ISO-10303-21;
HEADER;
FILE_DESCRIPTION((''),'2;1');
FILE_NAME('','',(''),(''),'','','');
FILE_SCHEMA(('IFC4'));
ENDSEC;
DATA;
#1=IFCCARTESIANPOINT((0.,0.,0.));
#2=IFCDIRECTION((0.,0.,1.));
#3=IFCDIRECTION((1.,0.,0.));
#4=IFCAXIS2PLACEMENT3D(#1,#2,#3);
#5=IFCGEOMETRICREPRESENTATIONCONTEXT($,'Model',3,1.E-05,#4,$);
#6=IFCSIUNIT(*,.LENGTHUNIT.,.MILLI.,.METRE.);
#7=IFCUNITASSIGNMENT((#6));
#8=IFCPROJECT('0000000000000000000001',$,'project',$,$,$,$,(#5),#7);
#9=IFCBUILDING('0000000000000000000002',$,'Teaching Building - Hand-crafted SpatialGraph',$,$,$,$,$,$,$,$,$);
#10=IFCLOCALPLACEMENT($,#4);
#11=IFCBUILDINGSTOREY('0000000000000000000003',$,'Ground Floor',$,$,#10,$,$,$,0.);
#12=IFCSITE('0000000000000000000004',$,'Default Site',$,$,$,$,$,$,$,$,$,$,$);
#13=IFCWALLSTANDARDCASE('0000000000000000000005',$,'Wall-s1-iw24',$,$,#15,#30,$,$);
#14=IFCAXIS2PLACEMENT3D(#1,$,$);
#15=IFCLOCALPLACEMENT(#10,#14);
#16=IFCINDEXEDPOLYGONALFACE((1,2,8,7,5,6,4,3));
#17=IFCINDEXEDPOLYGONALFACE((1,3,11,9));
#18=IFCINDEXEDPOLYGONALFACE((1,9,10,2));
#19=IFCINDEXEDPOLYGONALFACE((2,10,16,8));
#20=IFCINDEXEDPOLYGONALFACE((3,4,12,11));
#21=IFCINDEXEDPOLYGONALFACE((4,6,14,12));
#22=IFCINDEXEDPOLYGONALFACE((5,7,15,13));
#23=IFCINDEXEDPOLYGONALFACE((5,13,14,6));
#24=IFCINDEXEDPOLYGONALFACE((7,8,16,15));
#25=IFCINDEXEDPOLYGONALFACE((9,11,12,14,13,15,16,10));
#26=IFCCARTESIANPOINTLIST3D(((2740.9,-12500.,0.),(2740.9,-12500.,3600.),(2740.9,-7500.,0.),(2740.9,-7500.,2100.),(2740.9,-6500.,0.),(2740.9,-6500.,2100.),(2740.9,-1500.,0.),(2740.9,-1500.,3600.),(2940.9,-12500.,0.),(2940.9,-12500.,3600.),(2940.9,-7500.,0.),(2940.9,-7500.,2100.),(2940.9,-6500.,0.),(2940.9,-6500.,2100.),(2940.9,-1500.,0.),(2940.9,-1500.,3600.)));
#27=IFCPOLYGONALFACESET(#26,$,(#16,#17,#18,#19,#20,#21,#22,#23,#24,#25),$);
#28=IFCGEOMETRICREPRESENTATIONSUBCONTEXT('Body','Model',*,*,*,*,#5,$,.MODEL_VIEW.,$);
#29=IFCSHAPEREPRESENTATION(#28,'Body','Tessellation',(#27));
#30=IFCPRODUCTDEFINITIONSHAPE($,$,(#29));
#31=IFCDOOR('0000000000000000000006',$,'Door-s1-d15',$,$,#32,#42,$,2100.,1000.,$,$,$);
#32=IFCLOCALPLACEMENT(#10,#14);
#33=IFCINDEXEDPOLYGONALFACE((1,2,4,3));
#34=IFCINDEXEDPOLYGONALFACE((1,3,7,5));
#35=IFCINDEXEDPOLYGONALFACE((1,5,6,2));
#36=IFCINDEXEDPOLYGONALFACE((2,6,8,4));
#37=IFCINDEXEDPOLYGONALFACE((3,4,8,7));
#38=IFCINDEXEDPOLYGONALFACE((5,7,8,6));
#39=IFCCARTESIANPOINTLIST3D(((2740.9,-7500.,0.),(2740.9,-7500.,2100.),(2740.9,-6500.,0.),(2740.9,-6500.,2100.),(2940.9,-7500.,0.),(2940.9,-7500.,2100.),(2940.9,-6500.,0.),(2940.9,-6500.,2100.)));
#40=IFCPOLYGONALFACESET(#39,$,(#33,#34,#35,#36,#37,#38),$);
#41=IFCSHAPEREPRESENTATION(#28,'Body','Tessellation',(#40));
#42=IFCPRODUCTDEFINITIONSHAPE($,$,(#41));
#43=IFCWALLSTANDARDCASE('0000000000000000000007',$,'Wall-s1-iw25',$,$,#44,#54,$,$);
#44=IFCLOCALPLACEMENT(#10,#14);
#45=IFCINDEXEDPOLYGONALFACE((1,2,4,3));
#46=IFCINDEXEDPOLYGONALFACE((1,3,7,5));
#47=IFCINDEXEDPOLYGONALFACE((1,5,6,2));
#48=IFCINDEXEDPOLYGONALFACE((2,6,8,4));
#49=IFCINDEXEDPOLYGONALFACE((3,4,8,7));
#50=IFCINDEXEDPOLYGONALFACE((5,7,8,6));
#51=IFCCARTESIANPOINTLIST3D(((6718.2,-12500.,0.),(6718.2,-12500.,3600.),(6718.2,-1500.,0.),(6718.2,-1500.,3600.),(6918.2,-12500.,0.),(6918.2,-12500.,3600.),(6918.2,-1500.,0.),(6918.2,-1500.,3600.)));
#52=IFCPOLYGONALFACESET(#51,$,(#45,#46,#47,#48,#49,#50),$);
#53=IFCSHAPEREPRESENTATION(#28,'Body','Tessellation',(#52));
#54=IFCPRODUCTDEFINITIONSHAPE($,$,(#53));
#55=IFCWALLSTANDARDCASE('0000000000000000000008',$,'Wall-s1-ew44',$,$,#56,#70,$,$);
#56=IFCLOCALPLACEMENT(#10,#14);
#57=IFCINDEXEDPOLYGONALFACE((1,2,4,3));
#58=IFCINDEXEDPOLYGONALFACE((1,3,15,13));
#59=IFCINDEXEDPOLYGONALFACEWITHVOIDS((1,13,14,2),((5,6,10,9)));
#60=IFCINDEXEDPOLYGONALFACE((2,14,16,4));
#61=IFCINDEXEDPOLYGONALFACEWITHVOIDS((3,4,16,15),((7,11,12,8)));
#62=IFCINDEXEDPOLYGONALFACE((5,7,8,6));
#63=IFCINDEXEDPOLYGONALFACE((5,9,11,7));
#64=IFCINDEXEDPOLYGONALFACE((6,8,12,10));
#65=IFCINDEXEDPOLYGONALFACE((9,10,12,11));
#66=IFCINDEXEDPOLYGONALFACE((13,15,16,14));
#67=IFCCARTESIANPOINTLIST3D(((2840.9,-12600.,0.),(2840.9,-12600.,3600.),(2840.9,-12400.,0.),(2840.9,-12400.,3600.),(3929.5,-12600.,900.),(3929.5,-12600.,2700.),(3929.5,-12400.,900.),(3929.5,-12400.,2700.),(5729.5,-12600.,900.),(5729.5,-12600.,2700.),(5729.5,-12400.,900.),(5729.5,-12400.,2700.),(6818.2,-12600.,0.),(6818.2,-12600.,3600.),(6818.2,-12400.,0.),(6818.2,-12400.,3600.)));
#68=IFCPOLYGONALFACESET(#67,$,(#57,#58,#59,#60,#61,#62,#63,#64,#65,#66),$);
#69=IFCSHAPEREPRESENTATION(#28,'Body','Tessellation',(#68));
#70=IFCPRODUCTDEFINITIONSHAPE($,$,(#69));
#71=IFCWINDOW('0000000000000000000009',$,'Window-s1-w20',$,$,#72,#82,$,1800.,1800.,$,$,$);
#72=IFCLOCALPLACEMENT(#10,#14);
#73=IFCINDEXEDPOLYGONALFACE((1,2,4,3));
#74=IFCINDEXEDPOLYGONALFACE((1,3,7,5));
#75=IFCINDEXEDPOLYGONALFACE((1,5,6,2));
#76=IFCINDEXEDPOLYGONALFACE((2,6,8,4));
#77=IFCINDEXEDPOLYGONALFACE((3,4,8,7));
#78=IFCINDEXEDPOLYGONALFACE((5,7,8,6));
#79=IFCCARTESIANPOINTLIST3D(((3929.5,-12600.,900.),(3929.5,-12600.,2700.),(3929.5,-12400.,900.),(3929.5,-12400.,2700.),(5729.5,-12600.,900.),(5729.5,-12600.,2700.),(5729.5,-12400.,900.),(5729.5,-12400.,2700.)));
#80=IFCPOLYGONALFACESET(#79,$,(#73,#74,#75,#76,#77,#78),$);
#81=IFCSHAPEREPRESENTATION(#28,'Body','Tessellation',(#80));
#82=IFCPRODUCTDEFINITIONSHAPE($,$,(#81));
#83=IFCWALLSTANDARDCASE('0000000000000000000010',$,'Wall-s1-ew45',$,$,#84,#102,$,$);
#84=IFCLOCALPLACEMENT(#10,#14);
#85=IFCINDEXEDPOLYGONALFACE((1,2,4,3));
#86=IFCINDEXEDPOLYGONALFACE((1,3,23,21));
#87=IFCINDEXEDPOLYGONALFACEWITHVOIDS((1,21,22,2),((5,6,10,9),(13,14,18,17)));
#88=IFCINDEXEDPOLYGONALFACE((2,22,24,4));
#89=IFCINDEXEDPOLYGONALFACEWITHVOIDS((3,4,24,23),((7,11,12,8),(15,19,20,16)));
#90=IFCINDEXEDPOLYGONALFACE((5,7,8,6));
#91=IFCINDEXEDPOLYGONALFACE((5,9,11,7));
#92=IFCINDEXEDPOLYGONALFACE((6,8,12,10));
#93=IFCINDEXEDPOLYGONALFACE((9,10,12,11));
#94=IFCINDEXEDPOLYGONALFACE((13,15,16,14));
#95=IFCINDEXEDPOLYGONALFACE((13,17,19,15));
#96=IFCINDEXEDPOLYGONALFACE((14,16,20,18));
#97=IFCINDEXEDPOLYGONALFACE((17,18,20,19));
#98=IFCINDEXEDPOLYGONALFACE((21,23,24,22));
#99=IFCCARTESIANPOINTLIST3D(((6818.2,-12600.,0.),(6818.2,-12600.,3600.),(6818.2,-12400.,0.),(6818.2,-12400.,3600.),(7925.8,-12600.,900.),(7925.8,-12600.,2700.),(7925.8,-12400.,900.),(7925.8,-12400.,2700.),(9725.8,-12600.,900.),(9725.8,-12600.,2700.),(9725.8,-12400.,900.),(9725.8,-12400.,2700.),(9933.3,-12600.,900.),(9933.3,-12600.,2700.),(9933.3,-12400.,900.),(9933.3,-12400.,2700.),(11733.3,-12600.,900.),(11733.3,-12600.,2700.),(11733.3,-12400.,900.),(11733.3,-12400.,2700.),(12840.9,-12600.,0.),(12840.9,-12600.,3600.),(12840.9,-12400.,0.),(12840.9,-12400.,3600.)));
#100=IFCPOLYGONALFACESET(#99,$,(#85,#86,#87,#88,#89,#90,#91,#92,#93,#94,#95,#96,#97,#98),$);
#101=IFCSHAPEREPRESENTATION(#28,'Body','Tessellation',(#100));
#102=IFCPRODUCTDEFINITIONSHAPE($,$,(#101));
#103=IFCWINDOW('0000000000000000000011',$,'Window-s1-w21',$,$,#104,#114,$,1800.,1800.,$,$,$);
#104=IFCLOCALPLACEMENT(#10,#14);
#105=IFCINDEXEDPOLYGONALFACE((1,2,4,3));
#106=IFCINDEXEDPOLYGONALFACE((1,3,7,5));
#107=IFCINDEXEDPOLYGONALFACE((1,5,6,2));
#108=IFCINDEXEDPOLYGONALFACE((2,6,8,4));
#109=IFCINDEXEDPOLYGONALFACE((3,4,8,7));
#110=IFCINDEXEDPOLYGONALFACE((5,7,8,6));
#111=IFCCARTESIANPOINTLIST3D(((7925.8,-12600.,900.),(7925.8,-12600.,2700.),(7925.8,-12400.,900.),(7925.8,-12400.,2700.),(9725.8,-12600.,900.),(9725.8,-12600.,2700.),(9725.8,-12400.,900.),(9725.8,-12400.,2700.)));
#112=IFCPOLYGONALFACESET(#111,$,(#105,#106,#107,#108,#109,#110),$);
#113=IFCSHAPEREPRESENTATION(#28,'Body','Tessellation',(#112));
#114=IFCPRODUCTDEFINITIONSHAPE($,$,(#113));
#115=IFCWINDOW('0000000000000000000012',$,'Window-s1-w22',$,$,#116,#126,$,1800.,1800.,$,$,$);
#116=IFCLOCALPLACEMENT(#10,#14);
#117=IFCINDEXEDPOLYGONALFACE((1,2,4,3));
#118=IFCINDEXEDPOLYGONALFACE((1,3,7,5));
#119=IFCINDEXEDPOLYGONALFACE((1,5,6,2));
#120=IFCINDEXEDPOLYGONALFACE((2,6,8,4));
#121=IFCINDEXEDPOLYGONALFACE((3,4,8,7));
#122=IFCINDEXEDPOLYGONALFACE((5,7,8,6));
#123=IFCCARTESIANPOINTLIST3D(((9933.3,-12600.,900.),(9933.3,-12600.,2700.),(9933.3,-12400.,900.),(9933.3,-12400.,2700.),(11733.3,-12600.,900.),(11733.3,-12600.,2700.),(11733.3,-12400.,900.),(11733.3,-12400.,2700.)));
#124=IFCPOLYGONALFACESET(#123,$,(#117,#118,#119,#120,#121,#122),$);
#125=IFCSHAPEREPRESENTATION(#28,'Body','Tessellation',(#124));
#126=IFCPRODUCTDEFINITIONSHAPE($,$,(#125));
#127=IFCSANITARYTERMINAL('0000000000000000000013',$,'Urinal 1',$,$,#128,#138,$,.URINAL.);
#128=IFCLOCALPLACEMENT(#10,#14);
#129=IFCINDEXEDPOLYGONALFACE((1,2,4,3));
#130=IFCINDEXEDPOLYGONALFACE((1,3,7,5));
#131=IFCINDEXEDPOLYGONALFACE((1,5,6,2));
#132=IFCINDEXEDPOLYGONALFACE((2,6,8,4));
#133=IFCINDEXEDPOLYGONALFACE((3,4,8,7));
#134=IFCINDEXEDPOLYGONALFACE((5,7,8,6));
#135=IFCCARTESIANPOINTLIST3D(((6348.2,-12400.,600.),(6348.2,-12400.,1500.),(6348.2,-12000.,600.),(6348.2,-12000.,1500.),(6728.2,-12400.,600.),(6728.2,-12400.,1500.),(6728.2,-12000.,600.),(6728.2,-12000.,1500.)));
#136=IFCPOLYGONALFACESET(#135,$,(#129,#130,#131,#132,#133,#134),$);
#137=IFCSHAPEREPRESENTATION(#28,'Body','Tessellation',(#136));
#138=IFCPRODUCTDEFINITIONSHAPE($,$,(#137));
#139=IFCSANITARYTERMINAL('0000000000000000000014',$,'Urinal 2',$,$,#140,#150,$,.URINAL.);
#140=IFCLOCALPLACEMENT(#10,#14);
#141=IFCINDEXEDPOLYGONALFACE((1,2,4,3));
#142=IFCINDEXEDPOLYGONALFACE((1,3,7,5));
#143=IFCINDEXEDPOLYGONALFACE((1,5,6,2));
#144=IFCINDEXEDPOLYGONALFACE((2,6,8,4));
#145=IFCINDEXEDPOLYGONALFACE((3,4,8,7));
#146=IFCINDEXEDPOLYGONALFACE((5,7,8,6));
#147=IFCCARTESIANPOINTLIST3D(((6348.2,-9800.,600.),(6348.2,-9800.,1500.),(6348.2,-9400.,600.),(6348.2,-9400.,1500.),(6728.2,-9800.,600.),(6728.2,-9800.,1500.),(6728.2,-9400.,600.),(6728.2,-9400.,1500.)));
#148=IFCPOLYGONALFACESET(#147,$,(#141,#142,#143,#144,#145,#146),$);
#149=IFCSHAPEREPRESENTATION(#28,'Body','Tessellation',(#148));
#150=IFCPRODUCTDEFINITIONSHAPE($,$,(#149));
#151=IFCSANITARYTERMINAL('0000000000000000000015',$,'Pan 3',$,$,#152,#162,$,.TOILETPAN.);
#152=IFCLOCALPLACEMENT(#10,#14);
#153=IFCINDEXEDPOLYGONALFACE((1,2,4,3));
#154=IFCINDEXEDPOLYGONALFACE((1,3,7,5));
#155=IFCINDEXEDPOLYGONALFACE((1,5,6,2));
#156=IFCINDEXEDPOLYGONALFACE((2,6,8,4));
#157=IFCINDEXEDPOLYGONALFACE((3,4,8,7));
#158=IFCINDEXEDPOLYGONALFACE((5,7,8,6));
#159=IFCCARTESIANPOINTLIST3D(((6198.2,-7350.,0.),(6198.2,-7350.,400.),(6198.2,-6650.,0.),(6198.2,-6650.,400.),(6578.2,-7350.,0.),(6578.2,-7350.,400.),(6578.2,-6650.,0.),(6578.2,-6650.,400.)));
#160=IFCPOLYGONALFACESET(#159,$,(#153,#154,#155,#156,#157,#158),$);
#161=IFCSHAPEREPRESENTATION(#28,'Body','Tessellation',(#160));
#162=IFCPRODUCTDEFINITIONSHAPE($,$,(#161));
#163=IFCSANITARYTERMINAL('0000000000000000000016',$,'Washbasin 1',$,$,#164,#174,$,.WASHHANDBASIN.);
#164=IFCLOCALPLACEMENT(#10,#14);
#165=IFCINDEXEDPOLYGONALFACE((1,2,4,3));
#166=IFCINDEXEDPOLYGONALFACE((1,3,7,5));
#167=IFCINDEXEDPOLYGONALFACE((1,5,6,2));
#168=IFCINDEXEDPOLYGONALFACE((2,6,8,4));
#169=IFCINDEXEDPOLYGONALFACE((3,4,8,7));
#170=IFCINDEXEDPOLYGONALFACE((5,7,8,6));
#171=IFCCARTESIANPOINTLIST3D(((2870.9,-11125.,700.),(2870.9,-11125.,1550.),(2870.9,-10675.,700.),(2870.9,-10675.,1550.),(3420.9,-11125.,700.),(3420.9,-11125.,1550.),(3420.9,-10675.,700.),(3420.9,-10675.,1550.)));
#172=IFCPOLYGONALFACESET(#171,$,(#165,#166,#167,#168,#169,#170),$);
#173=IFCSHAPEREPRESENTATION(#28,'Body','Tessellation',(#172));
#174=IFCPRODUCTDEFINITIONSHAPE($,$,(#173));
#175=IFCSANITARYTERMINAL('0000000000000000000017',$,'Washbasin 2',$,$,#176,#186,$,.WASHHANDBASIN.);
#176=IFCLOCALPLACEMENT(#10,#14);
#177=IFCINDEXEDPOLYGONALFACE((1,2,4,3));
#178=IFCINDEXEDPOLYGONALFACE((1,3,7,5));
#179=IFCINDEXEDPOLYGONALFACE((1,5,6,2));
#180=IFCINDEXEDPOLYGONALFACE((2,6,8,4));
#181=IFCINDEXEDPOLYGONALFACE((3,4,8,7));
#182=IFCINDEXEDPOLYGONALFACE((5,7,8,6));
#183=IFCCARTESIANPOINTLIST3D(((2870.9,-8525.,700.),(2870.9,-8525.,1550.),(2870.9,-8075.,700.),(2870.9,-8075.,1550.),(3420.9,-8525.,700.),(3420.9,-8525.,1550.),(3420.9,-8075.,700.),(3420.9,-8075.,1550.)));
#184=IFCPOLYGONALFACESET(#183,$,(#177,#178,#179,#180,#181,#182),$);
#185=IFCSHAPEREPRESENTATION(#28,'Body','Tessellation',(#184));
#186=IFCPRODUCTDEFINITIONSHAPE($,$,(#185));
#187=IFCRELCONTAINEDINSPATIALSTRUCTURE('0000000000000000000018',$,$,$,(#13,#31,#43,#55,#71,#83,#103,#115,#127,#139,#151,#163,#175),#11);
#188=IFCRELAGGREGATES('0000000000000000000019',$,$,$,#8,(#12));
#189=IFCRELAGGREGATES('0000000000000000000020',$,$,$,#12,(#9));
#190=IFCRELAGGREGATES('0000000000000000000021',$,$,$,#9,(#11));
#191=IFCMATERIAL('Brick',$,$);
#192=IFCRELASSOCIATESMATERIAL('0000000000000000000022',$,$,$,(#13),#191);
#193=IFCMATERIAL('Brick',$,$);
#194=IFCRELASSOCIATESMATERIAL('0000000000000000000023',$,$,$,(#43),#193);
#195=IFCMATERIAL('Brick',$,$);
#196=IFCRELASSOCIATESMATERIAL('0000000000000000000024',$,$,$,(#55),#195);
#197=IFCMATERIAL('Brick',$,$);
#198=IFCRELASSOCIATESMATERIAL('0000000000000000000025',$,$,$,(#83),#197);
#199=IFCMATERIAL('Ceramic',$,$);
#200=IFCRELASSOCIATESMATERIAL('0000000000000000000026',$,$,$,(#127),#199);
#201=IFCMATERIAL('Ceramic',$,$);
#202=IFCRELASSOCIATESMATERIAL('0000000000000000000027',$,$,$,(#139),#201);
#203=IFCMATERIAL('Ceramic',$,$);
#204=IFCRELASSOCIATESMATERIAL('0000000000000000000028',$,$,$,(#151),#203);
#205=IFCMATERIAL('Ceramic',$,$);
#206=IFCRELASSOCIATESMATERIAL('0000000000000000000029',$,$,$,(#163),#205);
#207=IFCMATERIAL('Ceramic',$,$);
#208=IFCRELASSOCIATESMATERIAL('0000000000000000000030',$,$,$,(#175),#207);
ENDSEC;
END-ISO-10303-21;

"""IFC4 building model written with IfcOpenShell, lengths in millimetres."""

from ifc_helpers import new_model, si_unit, frame, frame_2d, origin_with_axes, origin_2d, place, context, subcontext, project, spatial, rectangle, extrude, material, element, fill, save


model = new_model("IFC4")

# Units and contexts
model_context = context("Model", 3, precision=1e-05, world=origin_with_axes())
body_context = subcontext(model_context, "Body", "Model", "MODEL_VIEW")
ifc_project = project(units=[si_unit("LENGTHUNIT", "METRE", prefix="MILLI")], contexts=[model_context])

# Site, building, storey
site = spatial("IfcSite", under=ifc_project, Name="Default Site")
building = spatial("IfcBuilding", under=site, Name="Teaching Building - Hand-crafted SpatialGraph")
storey_placement = place(None, origin_with_axes())
storey = spatial("IfcBuildingStorey", under=building, at=storey_placement, Name="Ground Floor", Elevation=0.0)

# Wall, opening, door
ifc_material_1 = material(Name="Brick")
wall_1_placement = place(storey_placement, frame((2840.9, -12500.0, 0.0), z_axis=(0.0, 0.0, 1.0), x_axis=(0.0, 1.0, 0.0)))
wall_1 = element("IfcWallStandardCase", 1, at=wall_1_placement, inside=storey, material=ifc_material_1, Name="Wall-s1-iw24", context=body_context, shape_type="SweptSolid", body=[
    extrude(rectangle(XDim=11000.0, YDim=200.0, at=frame_2d((5500.0, 0.0))), origin_with_axes(), (0.0, 0.0, 1.0), 3600.0),
])
opening_1_placement = place(wall_1_placement, frame((5000.0, 0.0, 0.0), z_axis=(0.0, 0.0, 1.0), x_axis=(1.0, 0.0, 0.0)))
opening_1 = element("IfcOpeningElement", 2, at=opening_1_placement, cuts=wall_1, context=body_context, shape_type="SweptSolid", body=[
    extrude(rectangle(XDim=1000.0, YDim=400.0, at=frame_2d((500.0, 0.0))), origin_with_axes(), (0.0, 0.0, 1.0), 2100.0),
])
door_placement = place(storey_placement, frame((2840.9, -7500.0, 0.0), z_axis=(0.0, 0.0, 1.0), x_axis=(0.0, 1.0, 0.0)))
door = element("IfcDoor", 3, at=door_placement, inside=storey, Name="Door-s1-d15", OverallHeight=2100.0, OverallWidth=1000.0, context=body_context, shape_type="SweptSolid", body=[
    extrude(rectangle(XDim=1000.0, YDim=200.0, at=frame_2d((500.0, 0.0))), origin_with_axes(), (0.0, 0.0, 1.0), 2100.0),
])
fill(opening_1, door)

# Wall
ifc_material_2 = material(Name="Brick")
wall_2_placement = place(storey_placement, frame((6818.2, -12500.0, 0.0), z_axis=(0.0, 0.0, 1.0), x_axis=(0.0, 1.0, 0.0)))
element("IfcWallStandardCase", 4, at=wall_2_placement, inside=storey, material=ifc_material_2, Name="Wall-s1-iw25", context=body_context, shape_type="SweptSolid", body=[
    extrude(rectangle(XDim=11000.0, YDim=200.0, at=frame_2d((5500.0, 0.0))), origin_with_axes(), (0.0, 0.0, 1.0), 3600.0),
])

# Wall, opening, window
ifc_material_3 = material(Name="Brick")
wall_3_placement = place(storey_placement, frame((2840.9, -12500.0, 0.0), z_axis=(0.0, 0.0, 1.0), x_axis=(1.0, 0.0, 0.0)))
wall_3 = element("IfcWallStandardCase", 5, at=wall_3_placement, inside=storey, material=ifc_material_3, Name="Wall-s1-ew44", context=body_context, shape_type="SweptSolid", body=[
    extrude(rectangle(XDim=3977.3, YDim=200.0, at=frame_2d((1988.6, 0.0))), origin_with_axes(), (0.0, 0.0, 1.0), 3600.0),
])
opening_2_placement = place(wall_3_placement, frame((1088.6, 0.0, 900.0), z_axis=(0.0, 0.0, 1.0), x_axis=(1.0, 0.0, 0.0)))
opening_2 = element("IfcOpeningElement", 6, at=opening_2_placement, cuts=wall_3, context=body_context, shape_type="SweptSolid", body=[
    extrude(rectangle(XDim=1800.0, YDim=400.0, at=frame_2d((900.0, 0.0))), origin_with_axes(), (0.0, 0.0, 1.0), 1800.0),
])
window_1_placement = place(storey_placement, frame((3929.5, -12500.0, 900.0), z_axis=(0.0, 0.0, 1.0), x_axis=(1.0, 0.0, 0.0)))
window_1 = element("IfcWindow", 7, at=window_1_placement, inside=storey, Name="Window-s1-w20", OverallHeight=1800.0, OverallWidth=1800.0, context=body_context, shape_type="SweptSolid", body=[
    extrude(rectangle(XDim=1800.0, YDim=200.0, at=frame_2d((900.0, 0.0))), origin_with_axes(), (0.0, 0.0, 1.0), 1800.0),
])
fill(opening_2, window_1)

# Wall, openings, windows
ifc_material_4 = material(Name="Brick")
wall_4_placement = place(storey_placement, frame((6818.2, -12500.0, 0.0), z_axis=(0.0, 0.0, 1.0), x_axis=(1.0, 0.0, 0.0)))
wall_4 = element("IfcWallStandardCase", 8, at=wall_4_placement, inside=storey, material=ifc_material_4, Name="Wall-s1-ew45", context=body_context, shape_type="SweptSolid", body=[
    extrude(rectangle(XDim=6022.7, YDim=200.0, at=frame_2d((3011.4, 0.0))), origin_with_axes(), (0.0, 0.0, 1.0), 3600.0),
])
opening_3_placement = place(wall_4_placement, frame((1107.6, 0.0, 900.0), z_axis=(0.0, 0.0, 1.0), x_axis=(1.0, 0.0, 0.0)))
opening_3 = element("IfcOpeningElement", 9, at=opening_3_placement, cuts=wall_4, context=body_context, shape_type="SweptSolid", body=[
    extrude(rectangle(XDim=1800.0, YDim=400.0, at=frame_2d((900.0, 0.0))), origin_with_axes(), (0.0, 0.0, 1.0), 1800.0),
])
opening_4_placement = place(wall_4_placement, frame((3115.2, 0.0, 900.0), z_axis=(0.0, 0.0, 1.0), x_axis=(1.0, 0.0, 0.0)))
opening_4 = element("IfcOpeningElement", 10, at=opening_4_placement, cuts=wall_4, context=body_context, shape_type="SweptSolid", body=[
    extrude(rectangle(XDim=1800.0, YDim=400.0, at=frame_2d((900.0, 0.0))), origin_with_axes(), (0.0, 0.0, 1.0), 1800.0),
])
window_2_placement = place(storey_placement, frame((7925.8, -12500.0, 900.0), z_axis=(0.0, 0.0, 1.0), x_axis=(1.0, 0.0, 0.0)))
window_2 = element("IfcWindow", 11, at=window_2_placement, inside=storey, Name="Window-s1-w21", OverallHeight=1800.0, OverallWidth=1800.0, context=body_context, shape_type="SweptSolid", body=[
    extrude(rectangle(XDim=1800.0, YDim=200.0, at=frame_2d((900.0, 0.0))), origin_with_axes(), (0.0, 0.0, 1.0), 1800.0),
])
fill(opening_3, window_2)
window_3_placement = place(storey_placement, frame((9933.3, -12500.0, 900.0), z_axis=(0.0, 0.0, 1.0), x_axis=(1.0, 0.0, 0.0)))
window_3 = element("IfcWindow", 12, at=window_3_placement, inside=storey, Name="Window-s1-w22", OverallHeight=1800.0, OverallWidth=1800.0, context=body_context, shape_type="SweptSolid", body=[
    extrude(rectangle(XDim=1800.0, YDim=200.0, at=frame_2d((900.0, 0.0))), origin_with_axes(), (0.0, 0.0, 1.0), 1800.0),
])
fill(opening_4, window_3)

# Sanitary terminals
ifc_material_5 = material(Name="Ceramic")
sanitary_terminal_1_placement = place(storey_placement, frame((6538.2, -12200.0, 600.0), z_axis=(0.0, 0.0, 1.0), x_axis=(0.0, 1.0, 0.0)))
element("IfcSanitaryTerminal", 13, at=sanitary_terminal_1_placement, inside=storey, material=ifc_material_5, Name="Urinal 1", PredefinedType="URINAL", context=body_context, shape_type="SweptSolid", body=[
    extrude(rectangle(XDim=400.0, YDim=380.0, at=origin_2d()), origin_with_axes(), (0.0, 0.0, 1.0), 900.0),
])
ifc_material_6 = material(Name="Ceramic")
sanitary_terminal_2_placement = place(storey_placement, frame((6538.2, -9600.0, 600.0), z_axis=(0.0, 0.0, 1.0), x_axis=(0.0, 1.0, 0.0)))
element("IfcSanitaryTerminal", 14, at=sanitary_terminal_2_placement, inside=storey, material=ifc_material_6, Name="Urinal 2", PredefinedType="URINAL", context=body_context, shape_type="SweptSolid", body=[
    extrude(rectangle(XDim=400.0, YDim=380.0, at=origin_2d()), origin_with_axes(), (0.0, 0.0, 1.0), 900.0),
])
ifc_material_7 = material(Name="Ceramic")
sanitary_terminal_3_placement = place(storey_placement, frame((6388.2, -7000.0, 0.0), z_axis=(0.0, 0.0, 1.0), x_axis=(0.0, 1.0, 0.0)))
element("IfcSanitaryTerminal", 15, at=sanitary_terminal_3_placement, inside=storey, material=ifc_material_7, Name="Pan 3", PredefinedType="TOILETPAN", context=body_context, shape_type="SweptSolid", body=[
    extrude(rectangle(XDim=700.0, YDim=380.0, at=origin_2d()), origin_with_axes(), (0.0, 0.0, 1.0), 400.0),
])
ifc_material_8 = material(Name="Ceramic")
sanitary_terminal_4_placement = place(storey_placement, frame((3145.9, -10900.0, 700.0), z_axis=(0.0, 0.0, 1.0), x_axis=(0.0, 1.0, 0.0)))
element("IfcSanitaryTerminal", 16, at=sanitary_terminal_4_placement, inside=storey, material=ifc_material_8, Name="Washbasin 1", PredefinedType="WASHHANDBASIN", context=body_context, shape_type="SweptSolid", body=[
    extrude(rectangle(XDim=450.0, YDim=550.0, at=origin_2d()), origin_with_axes(), (0.0, 0.0, 1.0), 850.0),
])
ifc_material_9 = material(Name="Ceramic")
sanitary_terminal_5_placement = place(storey_placement, frame((3145.9, -8300.0, 700.0), z_axis=(0.0, 0.0, 1.0), x_axis=(0.0, 1.0, 0.0)))
element("IfcSanitaryTerminal", 17, at=sanitary_terminal_5_placement, inside=storey, material=ifc_material_9, Name="Washbasin 2", PredefinedType="WASHHANDBASIN", context=body_context, shape_type="SweptSolid", body=[
    extrude(rectangle(XDim=450.0, YDim=550.0, at=origin_2d()), origin_with_axes(), (0.0, 0.0, 1.0), 850.0),
])

save(model, "model.ifc")
